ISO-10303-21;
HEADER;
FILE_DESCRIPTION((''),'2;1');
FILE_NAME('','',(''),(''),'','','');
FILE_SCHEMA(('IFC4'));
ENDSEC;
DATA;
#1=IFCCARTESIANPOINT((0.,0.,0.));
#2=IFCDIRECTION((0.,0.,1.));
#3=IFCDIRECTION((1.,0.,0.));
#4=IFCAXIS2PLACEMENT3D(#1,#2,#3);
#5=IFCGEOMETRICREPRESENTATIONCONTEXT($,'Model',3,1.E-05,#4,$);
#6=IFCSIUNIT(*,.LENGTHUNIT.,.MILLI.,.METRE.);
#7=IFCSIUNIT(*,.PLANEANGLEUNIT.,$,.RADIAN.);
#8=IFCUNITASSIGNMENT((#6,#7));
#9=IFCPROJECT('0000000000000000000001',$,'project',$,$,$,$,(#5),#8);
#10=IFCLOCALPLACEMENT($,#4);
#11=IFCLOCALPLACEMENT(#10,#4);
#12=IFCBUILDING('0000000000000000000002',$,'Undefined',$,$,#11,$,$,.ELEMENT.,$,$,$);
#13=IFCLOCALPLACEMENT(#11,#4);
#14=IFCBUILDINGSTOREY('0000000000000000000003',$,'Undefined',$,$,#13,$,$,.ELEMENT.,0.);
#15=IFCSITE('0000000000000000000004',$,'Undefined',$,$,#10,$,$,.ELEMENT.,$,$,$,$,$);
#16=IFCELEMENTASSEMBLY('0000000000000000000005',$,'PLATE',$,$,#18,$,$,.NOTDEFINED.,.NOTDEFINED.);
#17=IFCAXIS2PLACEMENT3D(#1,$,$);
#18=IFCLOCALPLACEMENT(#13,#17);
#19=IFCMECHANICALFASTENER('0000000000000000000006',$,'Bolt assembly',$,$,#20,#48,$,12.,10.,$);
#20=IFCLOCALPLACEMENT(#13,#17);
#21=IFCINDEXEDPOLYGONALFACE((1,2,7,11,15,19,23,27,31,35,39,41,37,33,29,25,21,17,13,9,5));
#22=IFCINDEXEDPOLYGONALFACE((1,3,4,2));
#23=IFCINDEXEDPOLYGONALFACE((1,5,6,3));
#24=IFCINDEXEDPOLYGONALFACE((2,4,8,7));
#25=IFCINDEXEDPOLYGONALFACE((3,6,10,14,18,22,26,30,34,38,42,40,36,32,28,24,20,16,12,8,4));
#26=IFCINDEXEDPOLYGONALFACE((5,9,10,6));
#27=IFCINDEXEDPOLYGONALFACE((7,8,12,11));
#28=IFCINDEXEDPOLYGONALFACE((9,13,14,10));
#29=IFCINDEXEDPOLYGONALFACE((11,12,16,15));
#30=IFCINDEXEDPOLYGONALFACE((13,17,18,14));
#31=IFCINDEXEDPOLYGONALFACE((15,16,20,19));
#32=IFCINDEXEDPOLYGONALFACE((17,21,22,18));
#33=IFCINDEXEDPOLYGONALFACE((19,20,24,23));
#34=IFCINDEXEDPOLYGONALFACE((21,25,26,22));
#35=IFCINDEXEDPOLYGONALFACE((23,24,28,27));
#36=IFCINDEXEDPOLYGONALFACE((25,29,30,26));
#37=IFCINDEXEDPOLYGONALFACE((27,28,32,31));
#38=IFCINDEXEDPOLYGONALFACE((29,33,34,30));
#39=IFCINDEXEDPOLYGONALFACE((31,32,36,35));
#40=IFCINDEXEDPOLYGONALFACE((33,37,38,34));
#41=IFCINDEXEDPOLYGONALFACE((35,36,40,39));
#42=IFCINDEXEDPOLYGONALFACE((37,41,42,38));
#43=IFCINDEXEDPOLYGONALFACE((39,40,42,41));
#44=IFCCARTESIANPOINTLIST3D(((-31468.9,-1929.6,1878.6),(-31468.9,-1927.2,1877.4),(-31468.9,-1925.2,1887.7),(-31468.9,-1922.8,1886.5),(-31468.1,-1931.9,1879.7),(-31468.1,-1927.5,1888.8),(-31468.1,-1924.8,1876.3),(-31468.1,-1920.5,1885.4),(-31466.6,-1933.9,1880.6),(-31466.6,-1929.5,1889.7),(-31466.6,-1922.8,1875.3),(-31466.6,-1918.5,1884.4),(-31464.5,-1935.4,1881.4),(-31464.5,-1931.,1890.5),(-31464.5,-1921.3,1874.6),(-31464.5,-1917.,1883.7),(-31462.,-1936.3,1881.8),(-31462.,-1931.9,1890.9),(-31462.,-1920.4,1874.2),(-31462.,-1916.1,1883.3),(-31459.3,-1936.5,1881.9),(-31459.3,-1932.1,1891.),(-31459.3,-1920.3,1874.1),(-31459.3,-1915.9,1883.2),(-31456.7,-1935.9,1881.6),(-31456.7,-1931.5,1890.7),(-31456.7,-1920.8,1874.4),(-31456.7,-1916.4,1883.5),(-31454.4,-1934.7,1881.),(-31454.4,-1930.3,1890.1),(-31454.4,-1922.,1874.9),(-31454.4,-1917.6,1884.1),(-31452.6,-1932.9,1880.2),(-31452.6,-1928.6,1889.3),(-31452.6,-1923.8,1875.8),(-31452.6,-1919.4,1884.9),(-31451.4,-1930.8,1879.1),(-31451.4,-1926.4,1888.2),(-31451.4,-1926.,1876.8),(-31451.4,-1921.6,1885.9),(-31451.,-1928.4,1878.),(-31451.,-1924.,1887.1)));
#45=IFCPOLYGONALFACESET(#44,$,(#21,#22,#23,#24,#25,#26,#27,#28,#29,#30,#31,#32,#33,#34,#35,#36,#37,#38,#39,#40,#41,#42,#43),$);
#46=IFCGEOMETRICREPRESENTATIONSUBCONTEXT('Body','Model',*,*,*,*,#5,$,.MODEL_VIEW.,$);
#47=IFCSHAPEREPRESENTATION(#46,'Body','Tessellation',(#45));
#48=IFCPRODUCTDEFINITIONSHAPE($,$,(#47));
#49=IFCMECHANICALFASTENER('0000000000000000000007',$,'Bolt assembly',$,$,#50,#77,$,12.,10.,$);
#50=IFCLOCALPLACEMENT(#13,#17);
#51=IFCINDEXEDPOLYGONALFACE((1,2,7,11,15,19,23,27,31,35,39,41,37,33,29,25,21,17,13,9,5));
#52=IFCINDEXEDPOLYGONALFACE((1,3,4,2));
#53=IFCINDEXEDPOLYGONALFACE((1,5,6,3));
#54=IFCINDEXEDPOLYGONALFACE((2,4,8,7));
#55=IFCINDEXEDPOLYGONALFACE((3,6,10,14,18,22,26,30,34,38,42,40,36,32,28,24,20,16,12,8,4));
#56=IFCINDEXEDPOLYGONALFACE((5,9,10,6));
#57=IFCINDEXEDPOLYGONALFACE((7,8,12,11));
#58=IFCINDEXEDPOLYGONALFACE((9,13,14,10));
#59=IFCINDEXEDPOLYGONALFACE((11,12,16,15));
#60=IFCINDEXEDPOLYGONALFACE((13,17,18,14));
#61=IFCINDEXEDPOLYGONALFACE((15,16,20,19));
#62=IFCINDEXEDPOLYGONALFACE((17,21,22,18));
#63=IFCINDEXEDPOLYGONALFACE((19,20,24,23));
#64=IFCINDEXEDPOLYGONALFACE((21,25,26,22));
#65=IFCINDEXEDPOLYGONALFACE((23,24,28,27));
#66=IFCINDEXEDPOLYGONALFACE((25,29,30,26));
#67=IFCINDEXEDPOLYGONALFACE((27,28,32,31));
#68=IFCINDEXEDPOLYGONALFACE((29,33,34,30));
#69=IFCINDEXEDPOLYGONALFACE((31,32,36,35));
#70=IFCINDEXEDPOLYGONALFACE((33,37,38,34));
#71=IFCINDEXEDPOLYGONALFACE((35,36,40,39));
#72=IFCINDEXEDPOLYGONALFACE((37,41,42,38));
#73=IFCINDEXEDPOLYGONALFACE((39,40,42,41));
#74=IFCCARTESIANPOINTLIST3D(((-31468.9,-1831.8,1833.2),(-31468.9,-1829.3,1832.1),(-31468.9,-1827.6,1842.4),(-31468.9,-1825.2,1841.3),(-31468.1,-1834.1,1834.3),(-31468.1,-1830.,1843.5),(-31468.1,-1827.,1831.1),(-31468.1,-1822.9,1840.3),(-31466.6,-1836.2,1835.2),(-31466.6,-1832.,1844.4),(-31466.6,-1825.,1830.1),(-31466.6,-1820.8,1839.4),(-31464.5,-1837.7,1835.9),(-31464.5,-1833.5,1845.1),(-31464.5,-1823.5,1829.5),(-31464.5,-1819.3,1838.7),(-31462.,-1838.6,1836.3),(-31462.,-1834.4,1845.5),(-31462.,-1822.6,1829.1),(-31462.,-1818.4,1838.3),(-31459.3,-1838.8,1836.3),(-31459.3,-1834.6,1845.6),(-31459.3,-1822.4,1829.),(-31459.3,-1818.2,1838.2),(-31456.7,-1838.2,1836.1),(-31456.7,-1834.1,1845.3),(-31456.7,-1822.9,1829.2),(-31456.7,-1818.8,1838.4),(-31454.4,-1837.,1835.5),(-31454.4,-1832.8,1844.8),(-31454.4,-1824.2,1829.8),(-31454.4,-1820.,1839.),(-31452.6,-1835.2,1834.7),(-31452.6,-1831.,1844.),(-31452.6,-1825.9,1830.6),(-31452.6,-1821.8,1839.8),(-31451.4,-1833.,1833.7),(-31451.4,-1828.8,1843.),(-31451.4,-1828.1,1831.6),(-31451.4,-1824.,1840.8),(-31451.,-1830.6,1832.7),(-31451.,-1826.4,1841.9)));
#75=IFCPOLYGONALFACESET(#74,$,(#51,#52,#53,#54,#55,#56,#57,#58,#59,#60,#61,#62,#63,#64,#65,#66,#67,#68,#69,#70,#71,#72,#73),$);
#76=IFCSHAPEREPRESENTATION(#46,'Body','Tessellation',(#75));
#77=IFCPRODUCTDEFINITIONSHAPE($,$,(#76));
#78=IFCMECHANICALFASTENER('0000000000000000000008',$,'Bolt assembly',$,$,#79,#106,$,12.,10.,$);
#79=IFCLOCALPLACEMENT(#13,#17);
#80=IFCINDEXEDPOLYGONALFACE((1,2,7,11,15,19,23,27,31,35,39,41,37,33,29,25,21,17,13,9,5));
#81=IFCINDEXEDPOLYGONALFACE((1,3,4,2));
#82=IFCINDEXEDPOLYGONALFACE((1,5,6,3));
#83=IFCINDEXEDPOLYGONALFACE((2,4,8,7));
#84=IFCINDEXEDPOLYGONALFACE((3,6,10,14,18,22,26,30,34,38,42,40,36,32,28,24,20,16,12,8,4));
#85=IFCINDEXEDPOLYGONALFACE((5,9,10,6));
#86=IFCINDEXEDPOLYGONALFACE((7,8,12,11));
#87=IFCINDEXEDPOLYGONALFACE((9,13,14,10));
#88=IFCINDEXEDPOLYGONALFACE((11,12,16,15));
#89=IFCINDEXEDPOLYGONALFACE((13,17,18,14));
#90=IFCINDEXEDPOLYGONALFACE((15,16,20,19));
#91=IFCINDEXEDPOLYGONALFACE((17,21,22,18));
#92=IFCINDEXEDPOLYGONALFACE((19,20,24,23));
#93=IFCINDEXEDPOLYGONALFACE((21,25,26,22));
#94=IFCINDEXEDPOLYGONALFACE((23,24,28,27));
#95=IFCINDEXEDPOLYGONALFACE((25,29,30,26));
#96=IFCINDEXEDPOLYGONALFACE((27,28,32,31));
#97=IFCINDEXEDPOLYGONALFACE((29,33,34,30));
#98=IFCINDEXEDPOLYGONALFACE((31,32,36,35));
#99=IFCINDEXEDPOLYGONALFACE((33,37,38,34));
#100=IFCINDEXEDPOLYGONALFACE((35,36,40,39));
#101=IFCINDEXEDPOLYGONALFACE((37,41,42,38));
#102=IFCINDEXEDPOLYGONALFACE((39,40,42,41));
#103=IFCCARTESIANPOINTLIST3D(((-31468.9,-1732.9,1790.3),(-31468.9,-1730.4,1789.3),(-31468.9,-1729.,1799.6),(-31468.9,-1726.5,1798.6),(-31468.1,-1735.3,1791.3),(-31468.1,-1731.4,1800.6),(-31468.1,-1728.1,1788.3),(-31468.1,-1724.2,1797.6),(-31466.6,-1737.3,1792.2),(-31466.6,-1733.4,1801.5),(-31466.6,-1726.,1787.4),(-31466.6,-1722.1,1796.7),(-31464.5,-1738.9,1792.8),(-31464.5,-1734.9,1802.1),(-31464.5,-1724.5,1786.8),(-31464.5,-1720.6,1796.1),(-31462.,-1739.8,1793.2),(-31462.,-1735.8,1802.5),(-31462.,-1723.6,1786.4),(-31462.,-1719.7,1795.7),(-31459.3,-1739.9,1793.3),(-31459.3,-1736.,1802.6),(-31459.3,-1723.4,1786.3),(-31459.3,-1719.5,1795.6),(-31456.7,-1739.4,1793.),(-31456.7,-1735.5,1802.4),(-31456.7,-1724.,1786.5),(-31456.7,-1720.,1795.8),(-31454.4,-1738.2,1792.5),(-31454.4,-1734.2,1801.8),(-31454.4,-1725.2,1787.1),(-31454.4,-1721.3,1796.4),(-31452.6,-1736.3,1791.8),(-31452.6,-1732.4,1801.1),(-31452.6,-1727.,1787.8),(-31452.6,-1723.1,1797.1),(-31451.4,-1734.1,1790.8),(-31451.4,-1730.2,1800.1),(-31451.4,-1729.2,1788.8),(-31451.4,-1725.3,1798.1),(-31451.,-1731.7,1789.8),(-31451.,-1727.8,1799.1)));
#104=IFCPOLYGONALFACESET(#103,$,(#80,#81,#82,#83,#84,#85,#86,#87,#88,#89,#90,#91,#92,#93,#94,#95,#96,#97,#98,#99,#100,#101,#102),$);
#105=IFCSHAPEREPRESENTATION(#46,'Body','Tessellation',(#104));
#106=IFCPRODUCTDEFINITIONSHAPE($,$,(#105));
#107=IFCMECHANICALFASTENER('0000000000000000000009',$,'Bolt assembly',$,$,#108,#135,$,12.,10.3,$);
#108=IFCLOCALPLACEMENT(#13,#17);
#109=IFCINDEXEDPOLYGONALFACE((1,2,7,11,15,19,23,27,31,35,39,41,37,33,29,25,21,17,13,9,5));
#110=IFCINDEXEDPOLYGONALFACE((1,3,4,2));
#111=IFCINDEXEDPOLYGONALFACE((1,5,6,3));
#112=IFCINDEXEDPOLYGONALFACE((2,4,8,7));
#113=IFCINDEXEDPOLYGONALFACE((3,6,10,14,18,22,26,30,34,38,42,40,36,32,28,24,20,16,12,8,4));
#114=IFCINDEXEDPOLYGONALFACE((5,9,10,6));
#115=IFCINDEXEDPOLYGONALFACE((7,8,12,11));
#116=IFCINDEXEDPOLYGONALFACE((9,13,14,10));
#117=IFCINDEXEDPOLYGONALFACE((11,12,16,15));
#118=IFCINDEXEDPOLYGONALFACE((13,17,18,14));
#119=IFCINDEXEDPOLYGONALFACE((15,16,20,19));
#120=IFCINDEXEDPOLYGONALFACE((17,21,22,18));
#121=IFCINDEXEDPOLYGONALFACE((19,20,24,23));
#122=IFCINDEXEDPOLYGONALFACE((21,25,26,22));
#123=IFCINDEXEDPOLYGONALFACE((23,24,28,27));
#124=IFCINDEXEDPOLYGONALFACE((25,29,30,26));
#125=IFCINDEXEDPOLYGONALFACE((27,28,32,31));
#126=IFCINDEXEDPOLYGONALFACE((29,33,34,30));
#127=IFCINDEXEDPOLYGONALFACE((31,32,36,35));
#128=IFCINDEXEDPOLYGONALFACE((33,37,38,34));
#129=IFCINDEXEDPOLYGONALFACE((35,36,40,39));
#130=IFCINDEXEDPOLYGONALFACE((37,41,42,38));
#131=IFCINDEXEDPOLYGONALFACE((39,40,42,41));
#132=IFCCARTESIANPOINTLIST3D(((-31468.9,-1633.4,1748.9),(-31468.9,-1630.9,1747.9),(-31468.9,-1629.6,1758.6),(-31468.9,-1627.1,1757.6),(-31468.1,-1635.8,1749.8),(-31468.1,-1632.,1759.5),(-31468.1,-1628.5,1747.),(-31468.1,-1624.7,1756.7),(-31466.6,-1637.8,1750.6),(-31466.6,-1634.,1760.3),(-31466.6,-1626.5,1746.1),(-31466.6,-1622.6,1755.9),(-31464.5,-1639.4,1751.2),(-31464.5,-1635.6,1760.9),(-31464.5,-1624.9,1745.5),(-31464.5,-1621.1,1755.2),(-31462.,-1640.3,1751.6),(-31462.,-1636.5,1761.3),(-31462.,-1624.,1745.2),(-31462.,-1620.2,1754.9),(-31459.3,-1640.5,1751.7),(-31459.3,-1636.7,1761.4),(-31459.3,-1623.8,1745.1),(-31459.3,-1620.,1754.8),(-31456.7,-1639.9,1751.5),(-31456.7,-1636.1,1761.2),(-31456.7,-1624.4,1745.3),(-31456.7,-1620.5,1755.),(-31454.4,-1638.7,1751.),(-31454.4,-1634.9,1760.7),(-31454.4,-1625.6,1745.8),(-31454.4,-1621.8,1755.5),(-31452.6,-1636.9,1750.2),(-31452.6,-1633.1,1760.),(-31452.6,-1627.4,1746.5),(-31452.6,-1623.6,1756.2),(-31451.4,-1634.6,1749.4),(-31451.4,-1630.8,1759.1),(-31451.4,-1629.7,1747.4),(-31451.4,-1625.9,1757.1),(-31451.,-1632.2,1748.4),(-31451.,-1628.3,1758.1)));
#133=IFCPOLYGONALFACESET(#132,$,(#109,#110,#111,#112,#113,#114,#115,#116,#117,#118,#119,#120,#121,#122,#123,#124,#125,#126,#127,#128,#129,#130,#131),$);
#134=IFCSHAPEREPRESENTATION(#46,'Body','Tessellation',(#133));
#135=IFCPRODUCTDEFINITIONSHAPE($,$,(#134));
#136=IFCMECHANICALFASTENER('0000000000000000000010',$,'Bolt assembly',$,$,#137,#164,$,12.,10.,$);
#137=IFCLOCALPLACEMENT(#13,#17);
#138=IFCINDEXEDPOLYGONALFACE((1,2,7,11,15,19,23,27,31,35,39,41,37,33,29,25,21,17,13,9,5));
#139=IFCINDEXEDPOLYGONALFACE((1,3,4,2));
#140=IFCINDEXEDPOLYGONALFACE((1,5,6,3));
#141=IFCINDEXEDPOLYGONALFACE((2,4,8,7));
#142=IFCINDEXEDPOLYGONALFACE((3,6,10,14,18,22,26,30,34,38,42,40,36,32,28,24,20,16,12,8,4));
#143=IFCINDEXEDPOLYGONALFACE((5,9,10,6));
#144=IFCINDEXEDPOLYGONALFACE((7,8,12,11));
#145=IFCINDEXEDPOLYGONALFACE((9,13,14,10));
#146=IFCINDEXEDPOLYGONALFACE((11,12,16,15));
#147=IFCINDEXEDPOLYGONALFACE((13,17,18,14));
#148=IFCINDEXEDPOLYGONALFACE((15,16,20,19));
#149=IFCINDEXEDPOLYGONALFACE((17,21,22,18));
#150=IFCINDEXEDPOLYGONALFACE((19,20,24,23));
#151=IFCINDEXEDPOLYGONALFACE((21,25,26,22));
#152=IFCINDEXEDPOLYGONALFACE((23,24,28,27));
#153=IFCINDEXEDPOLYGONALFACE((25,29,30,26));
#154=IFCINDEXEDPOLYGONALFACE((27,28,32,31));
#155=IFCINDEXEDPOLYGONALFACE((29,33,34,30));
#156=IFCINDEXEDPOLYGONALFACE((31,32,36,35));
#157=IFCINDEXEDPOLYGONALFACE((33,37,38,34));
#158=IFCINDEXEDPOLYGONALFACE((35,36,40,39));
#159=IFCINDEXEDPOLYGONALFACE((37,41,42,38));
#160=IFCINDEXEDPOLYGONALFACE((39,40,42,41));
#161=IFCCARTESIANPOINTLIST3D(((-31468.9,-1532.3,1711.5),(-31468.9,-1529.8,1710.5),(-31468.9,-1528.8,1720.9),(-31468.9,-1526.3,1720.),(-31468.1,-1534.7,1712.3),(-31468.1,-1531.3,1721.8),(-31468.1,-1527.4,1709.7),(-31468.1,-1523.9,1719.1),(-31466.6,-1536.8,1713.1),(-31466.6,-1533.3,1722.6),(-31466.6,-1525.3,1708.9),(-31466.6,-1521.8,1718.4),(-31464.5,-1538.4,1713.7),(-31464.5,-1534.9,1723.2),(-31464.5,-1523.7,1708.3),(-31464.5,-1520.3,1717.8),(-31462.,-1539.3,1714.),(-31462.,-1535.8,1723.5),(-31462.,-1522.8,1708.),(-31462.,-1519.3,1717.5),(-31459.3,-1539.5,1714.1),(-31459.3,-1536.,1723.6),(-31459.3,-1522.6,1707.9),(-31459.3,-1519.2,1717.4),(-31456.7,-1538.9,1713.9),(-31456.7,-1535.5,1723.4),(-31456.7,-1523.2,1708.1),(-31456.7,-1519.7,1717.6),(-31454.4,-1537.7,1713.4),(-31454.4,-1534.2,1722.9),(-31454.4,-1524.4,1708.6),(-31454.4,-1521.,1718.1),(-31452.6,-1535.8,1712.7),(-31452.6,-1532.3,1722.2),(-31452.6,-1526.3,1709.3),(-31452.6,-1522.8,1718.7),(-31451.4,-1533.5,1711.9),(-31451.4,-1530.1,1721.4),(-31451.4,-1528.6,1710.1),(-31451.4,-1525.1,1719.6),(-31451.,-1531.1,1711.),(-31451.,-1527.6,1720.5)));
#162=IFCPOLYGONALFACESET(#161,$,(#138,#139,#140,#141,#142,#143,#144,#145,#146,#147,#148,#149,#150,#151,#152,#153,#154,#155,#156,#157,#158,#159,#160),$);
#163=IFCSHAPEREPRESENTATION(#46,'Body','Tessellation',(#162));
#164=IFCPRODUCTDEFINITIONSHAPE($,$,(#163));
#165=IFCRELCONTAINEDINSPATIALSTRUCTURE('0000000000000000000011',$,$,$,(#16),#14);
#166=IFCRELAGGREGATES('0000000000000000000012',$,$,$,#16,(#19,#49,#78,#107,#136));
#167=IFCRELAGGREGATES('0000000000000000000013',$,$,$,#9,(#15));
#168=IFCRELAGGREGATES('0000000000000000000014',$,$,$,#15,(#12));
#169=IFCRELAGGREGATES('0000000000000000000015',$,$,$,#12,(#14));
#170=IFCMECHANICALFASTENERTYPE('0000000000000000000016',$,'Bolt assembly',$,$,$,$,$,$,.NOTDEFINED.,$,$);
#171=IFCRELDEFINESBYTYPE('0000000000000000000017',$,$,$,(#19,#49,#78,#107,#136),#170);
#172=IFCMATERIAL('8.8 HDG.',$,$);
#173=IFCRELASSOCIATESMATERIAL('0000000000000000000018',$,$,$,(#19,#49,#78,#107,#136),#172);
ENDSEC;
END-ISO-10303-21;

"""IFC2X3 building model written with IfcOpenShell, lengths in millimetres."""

from ifc_helpers import new_model, si_unit, frame, origin_with_axes, origin_2d_with_axis, place, context, subcontext, project, spatial, circle, extrude, source, transform, mapped, material, type_object, element, aggregate, save


model = new_model("IFC2X3")

# Units and contexts
model_context = context("Model", 3, precision=1e-05, world=origin_with_axes())
body_context = subcontext(model_context, "Body", "Model", "MODEL_VIEW")
ifc_project = project(units=[si_unit("LENGTHUNIT", "METRE", prefix="MILLI"), si_unit("PLANEANGLEUNIT", "RADIAN")], contexts=[model_context])

# Site, building, storey
site_placement = place(None, origin_with_axes())
site = spatial("IfcSite", under=ifc_project, at=site_placement, Name="Undefined", CompositionType="ELEMENT")
building_placement = place(site_placement, origin_with_axes())
building = spatial("IfcBuilding", under=site, at=building_placement, Name="Undefined", CompositionType="ELEMENT")
storey_placement = place(building_placement, origin_with_axes())
storey = spatial("IfcBuildingStorey", under=building, at=storey_placement, Name="Undefined", CompositionType="ELEMENT", Elevation=0.0)

# Element assembly, mechanical fasteners
assembly_placement = place(storey_placement, origin_with_axes())
assembly = element("IfcElementAssembly", 1, at=assembly_placement, inside=storey, Name="PLATE", AssemblyPlace="NOTDEFINED", PredefinedType="NOTDEFINED")
ifc_material_1 = material(Name="8.8 HDG.")
mechanical_fastener_type = type_object("IfcMechanicalFastenerType", Name="Bolt assembly")
shared_shape_1 = source(origin_with_axes(), body_context, "Body", "SweptSolid", [
    extrude(circle(Radius=9.0, at=origin_2d_with_axis()), frame((0.0, 0.6, 0.0), z_axis=(0.0, 1.0, 0.0), x_axis=(1.0, 0.0, 0.0)), (0.0, 0.0, 1.0), 10.1),
])
mechanical_fastener_1_placement = place(assembly_placement, frame((-31460.0, -1928.6, 1877.5), z_axis=(0.000001, -0.901716, 0.432328), x_axis=(1.0, 0.000001, -0.000001)))
mechanical_fastener_1 = element("IfcMechanicalFastener", 2, at=mechanical_fastener_1_placement, type_object=mechanical_fastener_type, material=ifc_material_1, Name="Bolt assembly", NominalDiameter=12.0, NominalLength=10.0, context=body_context, shape_type="MappedRepresentation", body=[
    mapped(shared_shape_1, transform((0.0, 0.0, 0.0))),
])
shared_shape_2 = source(origin_with_axes(), body_context, "Body", "SweptSolid", [
    extrude(circle(Radius=9.0, at=origin_2d_with_axis()), frame((0.0, 0.7, 0.0), z_axis=(0.0, 1.0, 0.0), x_axis=(1.0, 0.0, 0.0)), (0.0, 0.0, 1.0), 10.1),
])
mechanical_fastener_2_placement = place(assembly_placement, frame((-31460.0, -1830.8, 1832.1), z_axis=(0.000001, -0.9119, 0.410413), x_axis=(1.0, 0.000001, -0.000001)))
mechanical_fastener_2 = element("IfcMechanicalFastener", 3, at=mechanical_fastener_2_placement, type_object=mechanical_fastener_type, material=ifc_material_1, Name="Bolt assembly", NominalDiameter=12.0, NominalLength=10.0, context=body_context, shape_type="MappedRepresentation", body=[
    mapped(shared_shape_2, transform((0.0, 0.0, 0.0))),
])
shared_shape_3 = source(origin_with_axes(), body_context, "Body", "SweptSolid", [
    extrude(circle(Radius=9.0, at=origin_2d_with_axis()), frame((0.0, 0.8, 0.0), z_axis=(0.0, 1.0, 0.0), x_axis=(1.0, 0.0, 0.0)), (0.0, 0.0, 1.0), 10.1),
])
mechanical_fastener_3_placement = place(assembly_placement, frame((-31460.0, -1732.0, 1789.0), z_axis=(0.000001, -0.921551, 0.388258), x_axis=(1.0, 0.000001, -0.000001)))
mechanical_fastener_3 = element("IfcMechanicalFastener", 4, at=mechanical_fastener_3_placement, type_object=mechanical_fastener_type, material=ifc_material_1, Name="Bolt assembly", NominalDiameter=12.0, NominalLength=10.0, context=body_context, shape_type="MappedRepresentation", body=[
    mapped(shared_shape_3, transform((0.0, 0.0, 0.0))),
])
shared_shape_4 = source(origin_with_axes(), body_context, "Body", "SweptSolid", [
    extrude(circle(Radius=9.0, at=origin_2d_with_axis()), frame((0.0, 0.0, 0.0), z_axis=(0.0, 1.0, 0.0), x_axis=(1.0, 0.0, 0.0)), (0.0, 0.0, 1.0), 10.4),
])
mechanical_fastener_4_placement = place(assembly_placement, frame((-31460.0, -1632.2, 1748.4), z_axis=(0.000001, -0.930663, 0.365877), x_axis=(1.0, 0.000001, -0.000001)))
mechanical_fastener_4 = element("IfcMechanicalFastener", 5, at=mechanical_fastener_4_placement, type_object=mechanical_fastener_type, material=ifc_material_1, Name="Bolt assembly", NominalDiameter=12.0, NominalLength=10.3, context=body_context, shape_type="MappedRepresentation", body=[
    mapped(shared_shape_4, transform((0.0, 0.0, 0.0))),
])
shared_shape_5 = source(origin_with_axes(), body_context, "Body", "SweptSolid", [
    extrude(circle(Radius=9.0, at=origin_2d_with_axis()), frame((0.0, 0.9, 0.0), z_axis=(0.0, 1.0, 0.0), x_axis=(1.0, 0.0, 0.0)), (0.0, 0.0, 1.0), 10.1),
])
mechanical_fastener_5_placement = place(assembly_placement, frame((-31460.0, -1531.4, 1710.1), z_axis=(0.000001, -0.939233, 0.343282), x_axis=(1.0, 0.000001, -0.000001)))
mechanical_fastener_5 = element("IfcMechanicalFastener", 6, at=mechanical_fastener_5_placement, type_object=mechanical_fastener_type, material=ifc_material_1, Name="Bolt assembly", NominalDiameter=12.0, NominalLength=10.0, context=body_context, shape_type="MappedRepresentation", body=[
    mapped(shared_shape_5, transform((0.0, 0.0, 0.0))),
])
aggregate(assembly, [mechanical_fastener_1, mechanical_fastener_2, mechanical_fastener_3, mechanical_fastener_4, mechanical_fastener_5])

save(model, "model.ifc")
